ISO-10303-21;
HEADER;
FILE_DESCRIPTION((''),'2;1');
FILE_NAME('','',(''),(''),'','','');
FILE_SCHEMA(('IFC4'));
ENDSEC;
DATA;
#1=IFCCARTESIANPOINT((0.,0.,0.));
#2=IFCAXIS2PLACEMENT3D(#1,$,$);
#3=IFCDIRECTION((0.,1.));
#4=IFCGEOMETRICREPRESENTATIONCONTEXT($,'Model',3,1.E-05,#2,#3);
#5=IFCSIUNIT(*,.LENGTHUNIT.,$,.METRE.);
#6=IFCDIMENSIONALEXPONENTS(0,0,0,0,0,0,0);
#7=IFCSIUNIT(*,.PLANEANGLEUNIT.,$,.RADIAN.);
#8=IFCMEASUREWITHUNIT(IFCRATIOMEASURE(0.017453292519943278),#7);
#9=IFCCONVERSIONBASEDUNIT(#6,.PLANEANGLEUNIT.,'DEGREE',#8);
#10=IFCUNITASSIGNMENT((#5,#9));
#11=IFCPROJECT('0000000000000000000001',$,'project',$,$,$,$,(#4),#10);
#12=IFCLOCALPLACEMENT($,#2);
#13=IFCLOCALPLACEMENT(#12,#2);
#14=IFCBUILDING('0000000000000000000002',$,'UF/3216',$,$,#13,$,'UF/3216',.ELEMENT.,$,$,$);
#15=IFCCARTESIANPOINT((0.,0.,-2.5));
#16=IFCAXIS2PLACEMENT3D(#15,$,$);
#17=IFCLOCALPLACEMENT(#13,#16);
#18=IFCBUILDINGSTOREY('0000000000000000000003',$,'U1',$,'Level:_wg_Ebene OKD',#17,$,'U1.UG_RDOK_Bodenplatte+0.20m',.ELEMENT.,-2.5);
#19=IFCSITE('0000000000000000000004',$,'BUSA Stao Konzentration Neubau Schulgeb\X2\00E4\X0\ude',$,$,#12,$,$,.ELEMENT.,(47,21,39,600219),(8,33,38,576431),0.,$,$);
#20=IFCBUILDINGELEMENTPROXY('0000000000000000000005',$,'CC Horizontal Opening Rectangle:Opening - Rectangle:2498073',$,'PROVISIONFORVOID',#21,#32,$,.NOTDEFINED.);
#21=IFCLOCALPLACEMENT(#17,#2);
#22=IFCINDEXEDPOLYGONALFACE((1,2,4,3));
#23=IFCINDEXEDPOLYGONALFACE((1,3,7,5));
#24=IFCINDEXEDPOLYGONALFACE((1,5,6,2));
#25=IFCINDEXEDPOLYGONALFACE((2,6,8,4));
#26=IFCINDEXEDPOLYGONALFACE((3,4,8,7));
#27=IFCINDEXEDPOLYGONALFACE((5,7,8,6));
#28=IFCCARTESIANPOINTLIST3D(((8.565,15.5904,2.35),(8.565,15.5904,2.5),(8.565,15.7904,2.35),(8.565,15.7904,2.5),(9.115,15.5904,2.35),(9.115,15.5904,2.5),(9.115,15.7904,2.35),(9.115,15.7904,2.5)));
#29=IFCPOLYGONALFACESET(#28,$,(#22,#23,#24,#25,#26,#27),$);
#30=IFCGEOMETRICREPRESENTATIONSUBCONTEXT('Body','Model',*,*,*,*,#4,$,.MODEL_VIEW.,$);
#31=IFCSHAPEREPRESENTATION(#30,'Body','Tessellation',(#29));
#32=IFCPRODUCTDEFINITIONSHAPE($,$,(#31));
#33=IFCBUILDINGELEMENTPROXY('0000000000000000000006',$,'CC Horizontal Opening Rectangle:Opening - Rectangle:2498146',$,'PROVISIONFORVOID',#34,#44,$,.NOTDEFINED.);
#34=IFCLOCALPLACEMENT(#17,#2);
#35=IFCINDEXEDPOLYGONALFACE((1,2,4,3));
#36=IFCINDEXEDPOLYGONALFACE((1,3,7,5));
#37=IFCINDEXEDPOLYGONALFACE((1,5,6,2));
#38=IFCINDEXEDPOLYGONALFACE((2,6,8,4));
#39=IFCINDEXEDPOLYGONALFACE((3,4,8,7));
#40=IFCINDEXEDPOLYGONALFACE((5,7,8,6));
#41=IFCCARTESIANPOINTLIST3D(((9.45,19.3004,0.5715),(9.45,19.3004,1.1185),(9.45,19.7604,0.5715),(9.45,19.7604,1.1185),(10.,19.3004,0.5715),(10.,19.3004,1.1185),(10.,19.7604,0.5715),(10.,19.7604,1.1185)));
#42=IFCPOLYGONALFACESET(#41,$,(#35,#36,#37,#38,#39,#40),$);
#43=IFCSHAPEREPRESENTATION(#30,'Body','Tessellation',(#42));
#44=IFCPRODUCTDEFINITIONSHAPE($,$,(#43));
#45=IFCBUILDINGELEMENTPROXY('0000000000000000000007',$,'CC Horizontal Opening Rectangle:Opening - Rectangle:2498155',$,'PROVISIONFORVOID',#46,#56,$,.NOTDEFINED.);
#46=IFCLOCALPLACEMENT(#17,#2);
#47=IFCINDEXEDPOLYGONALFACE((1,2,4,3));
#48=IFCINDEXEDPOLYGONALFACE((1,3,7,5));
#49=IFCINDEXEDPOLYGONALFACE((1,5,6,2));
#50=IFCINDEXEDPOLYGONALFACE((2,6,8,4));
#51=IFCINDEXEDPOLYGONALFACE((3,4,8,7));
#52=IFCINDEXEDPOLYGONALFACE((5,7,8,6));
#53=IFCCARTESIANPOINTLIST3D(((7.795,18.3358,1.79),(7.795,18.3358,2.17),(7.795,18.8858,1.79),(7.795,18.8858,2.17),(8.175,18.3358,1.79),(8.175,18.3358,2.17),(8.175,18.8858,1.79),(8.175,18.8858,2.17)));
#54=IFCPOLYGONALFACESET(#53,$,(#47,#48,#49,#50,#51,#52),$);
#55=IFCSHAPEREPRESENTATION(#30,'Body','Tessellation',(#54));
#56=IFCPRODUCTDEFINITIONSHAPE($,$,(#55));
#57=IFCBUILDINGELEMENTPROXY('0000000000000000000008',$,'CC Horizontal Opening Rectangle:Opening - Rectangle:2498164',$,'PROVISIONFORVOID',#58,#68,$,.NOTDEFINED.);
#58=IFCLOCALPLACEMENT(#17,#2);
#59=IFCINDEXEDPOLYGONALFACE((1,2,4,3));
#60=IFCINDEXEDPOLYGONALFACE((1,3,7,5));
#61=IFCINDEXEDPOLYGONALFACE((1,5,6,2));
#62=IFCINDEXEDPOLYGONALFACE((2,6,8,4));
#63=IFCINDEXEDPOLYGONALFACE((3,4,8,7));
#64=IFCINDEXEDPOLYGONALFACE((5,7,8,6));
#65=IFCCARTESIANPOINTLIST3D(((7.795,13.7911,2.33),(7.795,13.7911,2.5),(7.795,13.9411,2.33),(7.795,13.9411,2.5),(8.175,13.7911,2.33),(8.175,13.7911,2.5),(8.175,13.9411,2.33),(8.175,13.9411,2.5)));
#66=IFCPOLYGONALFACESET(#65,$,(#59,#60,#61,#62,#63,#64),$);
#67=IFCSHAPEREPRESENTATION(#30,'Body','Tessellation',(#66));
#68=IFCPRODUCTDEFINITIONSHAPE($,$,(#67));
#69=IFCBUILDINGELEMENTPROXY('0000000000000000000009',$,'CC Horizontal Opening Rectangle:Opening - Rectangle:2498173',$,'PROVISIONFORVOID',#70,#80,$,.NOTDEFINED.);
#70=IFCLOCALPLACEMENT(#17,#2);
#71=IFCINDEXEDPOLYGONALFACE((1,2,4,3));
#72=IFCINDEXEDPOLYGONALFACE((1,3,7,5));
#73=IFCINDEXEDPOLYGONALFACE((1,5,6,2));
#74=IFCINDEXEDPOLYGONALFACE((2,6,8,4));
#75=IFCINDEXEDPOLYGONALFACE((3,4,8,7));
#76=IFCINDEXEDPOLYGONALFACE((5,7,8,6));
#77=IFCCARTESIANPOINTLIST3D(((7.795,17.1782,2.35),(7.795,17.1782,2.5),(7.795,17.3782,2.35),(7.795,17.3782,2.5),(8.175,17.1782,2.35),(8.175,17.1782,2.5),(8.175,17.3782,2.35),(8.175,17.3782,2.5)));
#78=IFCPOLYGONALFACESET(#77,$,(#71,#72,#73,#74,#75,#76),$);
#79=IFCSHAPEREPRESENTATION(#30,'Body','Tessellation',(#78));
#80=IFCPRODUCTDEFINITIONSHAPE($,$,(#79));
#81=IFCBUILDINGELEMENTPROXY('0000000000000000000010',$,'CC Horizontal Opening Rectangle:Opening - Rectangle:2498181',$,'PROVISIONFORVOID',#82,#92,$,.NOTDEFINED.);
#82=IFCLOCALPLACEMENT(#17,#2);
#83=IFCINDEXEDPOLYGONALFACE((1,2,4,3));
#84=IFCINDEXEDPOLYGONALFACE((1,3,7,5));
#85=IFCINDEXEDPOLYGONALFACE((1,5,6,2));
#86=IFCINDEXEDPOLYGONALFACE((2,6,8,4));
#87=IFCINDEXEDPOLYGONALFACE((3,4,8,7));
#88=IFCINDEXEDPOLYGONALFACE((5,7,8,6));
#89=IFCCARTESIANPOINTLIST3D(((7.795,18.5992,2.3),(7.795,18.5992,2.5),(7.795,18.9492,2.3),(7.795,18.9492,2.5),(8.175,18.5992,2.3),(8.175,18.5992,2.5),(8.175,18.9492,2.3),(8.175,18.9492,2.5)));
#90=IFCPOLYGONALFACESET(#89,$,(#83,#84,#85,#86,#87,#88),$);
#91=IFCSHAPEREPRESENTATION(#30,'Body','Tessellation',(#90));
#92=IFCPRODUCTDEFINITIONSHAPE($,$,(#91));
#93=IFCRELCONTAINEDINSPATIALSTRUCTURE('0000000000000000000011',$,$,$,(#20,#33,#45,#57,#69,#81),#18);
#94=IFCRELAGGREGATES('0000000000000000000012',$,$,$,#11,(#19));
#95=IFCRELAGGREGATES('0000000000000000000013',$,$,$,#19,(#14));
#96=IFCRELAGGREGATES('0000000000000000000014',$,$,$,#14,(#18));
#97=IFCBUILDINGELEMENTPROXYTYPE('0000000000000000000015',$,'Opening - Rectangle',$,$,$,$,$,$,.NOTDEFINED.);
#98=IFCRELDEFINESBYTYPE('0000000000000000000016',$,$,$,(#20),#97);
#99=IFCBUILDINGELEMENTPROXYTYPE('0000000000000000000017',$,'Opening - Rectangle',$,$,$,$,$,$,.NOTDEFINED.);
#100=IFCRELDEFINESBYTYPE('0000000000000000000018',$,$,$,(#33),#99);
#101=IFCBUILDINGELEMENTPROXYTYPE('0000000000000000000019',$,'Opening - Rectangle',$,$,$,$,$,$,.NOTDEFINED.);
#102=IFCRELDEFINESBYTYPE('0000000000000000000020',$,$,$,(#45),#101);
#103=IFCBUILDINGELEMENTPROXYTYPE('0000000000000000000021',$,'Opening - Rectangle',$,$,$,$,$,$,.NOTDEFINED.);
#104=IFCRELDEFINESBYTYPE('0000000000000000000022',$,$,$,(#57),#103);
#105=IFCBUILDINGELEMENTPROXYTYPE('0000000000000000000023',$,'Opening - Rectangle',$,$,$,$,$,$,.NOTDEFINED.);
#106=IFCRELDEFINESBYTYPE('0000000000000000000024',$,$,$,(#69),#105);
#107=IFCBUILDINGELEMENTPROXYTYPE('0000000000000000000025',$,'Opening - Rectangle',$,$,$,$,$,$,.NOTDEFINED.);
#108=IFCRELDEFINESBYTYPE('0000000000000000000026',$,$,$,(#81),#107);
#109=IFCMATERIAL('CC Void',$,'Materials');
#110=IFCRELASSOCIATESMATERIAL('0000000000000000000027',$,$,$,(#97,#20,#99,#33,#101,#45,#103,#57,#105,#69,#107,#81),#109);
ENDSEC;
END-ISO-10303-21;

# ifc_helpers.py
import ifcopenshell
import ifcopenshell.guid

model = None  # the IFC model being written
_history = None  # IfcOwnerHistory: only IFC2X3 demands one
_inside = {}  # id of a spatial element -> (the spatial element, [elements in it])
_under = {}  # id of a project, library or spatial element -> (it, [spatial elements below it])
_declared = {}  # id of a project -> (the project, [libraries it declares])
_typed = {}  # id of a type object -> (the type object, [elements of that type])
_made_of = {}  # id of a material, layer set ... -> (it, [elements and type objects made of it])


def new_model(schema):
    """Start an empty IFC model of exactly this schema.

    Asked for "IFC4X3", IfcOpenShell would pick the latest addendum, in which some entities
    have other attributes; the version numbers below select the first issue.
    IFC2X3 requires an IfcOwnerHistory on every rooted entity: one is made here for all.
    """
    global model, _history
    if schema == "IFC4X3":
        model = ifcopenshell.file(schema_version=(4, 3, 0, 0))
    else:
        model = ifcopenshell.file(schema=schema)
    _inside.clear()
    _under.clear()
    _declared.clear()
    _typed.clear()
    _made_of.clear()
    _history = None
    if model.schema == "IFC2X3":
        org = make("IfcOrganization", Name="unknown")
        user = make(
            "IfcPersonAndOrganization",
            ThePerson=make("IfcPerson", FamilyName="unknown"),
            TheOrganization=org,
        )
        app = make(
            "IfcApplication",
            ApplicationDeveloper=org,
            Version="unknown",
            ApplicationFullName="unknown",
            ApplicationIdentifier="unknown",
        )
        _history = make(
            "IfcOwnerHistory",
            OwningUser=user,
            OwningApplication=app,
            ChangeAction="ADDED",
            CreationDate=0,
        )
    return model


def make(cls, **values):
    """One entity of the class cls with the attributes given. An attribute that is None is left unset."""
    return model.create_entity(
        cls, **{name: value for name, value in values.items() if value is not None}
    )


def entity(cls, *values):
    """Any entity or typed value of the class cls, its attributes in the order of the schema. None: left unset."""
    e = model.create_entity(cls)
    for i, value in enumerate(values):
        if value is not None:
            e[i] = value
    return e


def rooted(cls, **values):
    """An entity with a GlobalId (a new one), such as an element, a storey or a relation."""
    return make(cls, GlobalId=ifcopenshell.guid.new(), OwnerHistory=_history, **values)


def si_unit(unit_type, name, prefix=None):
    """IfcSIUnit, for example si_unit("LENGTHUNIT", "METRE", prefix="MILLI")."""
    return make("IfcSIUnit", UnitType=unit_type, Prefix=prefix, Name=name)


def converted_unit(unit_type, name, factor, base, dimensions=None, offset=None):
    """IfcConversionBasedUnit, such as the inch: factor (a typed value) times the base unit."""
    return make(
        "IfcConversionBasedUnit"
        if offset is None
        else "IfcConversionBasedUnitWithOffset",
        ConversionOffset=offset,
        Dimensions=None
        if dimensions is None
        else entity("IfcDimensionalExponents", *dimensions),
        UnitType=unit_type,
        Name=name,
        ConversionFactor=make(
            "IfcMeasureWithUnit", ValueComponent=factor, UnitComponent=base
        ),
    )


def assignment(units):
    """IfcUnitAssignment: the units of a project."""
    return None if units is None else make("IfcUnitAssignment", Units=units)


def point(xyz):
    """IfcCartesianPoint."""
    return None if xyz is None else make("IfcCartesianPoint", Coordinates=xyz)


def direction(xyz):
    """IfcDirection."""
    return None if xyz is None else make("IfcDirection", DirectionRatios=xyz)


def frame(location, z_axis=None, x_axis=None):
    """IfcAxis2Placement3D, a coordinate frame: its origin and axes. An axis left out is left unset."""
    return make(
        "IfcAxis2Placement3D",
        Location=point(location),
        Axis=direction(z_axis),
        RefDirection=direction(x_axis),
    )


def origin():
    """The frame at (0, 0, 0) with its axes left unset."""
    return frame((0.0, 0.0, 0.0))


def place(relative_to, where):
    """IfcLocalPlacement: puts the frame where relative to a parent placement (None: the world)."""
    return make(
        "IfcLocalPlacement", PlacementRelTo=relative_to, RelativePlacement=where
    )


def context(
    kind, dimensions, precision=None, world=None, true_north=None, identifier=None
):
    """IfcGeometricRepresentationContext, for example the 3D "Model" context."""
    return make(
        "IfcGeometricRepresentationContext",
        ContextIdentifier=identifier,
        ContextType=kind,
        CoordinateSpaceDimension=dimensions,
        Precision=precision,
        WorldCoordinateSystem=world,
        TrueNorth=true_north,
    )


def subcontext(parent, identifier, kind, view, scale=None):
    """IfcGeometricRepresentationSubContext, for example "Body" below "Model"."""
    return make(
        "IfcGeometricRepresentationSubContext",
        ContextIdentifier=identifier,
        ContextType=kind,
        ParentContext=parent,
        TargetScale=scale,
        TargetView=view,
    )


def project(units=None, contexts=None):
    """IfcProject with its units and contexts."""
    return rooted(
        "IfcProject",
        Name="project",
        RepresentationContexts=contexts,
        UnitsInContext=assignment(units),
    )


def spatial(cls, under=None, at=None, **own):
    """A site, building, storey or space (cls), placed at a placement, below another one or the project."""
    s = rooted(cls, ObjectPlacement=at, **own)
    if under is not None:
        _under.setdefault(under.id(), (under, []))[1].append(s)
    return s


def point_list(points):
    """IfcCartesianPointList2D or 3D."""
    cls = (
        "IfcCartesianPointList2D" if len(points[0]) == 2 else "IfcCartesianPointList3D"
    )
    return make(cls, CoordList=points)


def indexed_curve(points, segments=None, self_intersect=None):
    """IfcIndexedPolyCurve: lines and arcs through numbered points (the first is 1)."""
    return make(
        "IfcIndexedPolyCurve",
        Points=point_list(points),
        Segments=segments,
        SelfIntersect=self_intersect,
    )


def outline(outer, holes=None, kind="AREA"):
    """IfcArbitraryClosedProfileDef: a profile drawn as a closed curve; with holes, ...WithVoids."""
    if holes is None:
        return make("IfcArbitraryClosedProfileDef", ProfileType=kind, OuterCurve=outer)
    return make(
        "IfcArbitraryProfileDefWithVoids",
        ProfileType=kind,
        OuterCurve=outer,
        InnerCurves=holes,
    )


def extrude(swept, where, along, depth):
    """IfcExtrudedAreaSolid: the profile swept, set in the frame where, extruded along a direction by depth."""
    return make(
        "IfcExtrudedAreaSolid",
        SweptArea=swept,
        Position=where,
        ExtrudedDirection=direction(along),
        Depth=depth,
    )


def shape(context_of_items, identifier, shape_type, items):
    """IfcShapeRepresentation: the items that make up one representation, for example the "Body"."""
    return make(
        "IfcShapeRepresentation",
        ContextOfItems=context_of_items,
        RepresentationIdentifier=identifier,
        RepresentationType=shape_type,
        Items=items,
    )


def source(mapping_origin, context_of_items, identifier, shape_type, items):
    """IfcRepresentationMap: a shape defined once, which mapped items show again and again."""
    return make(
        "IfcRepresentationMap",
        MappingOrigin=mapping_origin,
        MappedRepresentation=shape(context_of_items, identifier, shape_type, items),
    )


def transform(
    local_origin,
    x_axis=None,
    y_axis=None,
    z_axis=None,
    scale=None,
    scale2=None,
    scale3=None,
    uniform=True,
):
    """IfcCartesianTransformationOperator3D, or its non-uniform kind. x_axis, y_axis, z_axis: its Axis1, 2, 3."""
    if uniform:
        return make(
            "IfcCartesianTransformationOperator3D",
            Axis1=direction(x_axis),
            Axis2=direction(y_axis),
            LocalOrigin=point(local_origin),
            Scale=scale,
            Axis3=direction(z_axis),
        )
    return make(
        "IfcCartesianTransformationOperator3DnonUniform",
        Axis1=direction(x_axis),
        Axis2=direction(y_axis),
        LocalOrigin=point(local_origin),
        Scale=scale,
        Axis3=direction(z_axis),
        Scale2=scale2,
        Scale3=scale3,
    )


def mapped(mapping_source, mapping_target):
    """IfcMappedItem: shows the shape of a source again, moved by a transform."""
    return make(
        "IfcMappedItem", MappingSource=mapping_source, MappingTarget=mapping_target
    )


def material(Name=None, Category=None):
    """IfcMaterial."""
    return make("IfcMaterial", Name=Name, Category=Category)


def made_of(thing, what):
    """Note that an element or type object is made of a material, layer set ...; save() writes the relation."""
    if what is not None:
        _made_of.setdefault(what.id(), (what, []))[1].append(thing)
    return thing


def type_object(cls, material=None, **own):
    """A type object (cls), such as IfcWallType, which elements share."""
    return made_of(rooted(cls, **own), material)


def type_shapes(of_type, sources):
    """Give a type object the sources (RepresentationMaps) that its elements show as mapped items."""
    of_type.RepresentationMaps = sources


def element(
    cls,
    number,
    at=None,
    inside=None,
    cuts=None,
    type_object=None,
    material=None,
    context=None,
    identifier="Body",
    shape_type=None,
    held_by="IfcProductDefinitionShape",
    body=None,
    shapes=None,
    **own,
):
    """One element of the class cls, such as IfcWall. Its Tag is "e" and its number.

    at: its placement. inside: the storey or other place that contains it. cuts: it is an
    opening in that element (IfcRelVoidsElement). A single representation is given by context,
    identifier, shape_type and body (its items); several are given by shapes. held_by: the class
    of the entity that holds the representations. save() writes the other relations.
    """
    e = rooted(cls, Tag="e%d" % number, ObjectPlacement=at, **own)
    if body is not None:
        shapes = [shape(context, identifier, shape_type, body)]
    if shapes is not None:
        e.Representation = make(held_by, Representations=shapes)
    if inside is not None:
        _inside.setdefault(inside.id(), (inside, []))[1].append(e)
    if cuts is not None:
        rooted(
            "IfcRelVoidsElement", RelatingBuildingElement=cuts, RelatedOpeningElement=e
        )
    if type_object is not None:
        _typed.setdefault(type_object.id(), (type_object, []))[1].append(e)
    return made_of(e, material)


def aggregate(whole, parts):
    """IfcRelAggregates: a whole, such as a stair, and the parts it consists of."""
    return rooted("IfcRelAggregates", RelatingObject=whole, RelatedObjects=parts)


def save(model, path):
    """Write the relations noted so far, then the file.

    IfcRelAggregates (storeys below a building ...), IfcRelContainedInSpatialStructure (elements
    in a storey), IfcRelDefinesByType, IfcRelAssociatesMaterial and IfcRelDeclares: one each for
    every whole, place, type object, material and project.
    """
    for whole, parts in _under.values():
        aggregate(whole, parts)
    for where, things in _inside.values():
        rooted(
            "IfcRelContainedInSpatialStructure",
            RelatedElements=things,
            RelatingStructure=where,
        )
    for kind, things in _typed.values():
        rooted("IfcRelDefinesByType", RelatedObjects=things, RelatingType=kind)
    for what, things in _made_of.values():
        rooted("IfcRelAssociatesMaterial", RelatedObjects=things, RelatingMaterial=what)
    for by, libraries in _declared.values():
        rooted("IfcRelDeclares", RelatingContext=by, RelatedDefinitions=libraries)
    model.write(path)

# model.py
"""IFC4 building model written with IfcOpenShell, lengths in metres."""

from ifc_helpers import new_model, entity, si_unit, converted_unit, direction, frame, origin, place, context, subcontext, project, spatial, indexed_curve, outline, extrude, source, transform, mapped, material, type_object, type_shapes, element, save


model = new_model("IFC4")

# Units and contexts
model_context = context("Model", 3, precision=1e-05, world=origin(), true_north=direction((0.0, 1.0)))
body_context = subcontext(model_context, "Body", "Model", "MODEL_VIEW")
ifc_project = project(units=[si_unit("LENGTHUNIT", "METRE"), converted_unit("PLANEANGLEUNIT", "DEGREE", entity("IfcRatioMeasure", 0.017453292519943278), si_unit("PLANEANGLEUNIT", "RADIAN"), dimensions=[0, 0, 0, 0, 0, 0, 0])], contexts=[model_context])

# Site, building, storey
site_placement = place(None, origin())
site = spatial("IfcSite", under=ifc_project, at=site_placement, Name="BUSA Stao Konzentration Neubau Schulgebäude", CompositionType="ELEMENT", RefLatitude=(47, 21, 39, 600219), RefLongitude=(8, 33, 38, 576431), RefElevation=0.0)
building_placement = place(site_placement, origin())
building = spatial("IfcBuilding", under=site, at=building_placement, Name="UF/3216", LongName="UF/3216", CompositionType="ELEMENT")
storey_placement = place(building_placement, frame((0.0, 0.0, -2.5)))
storey = spatial("IfcBuildingStorey", under=building, at=storey_placement, Name="U1", ObjectType="Level:_wg_Ebene OKD", LongName="U1.UG_RDOK_Bodenplatte+0.20m", CompositionType="ELEMENT", Elevation=-2.5)

# Building element proxies
ifc_material_1 = material(Name="CC Void", Category="Materials")
building_element_proxy_type_1 = type_object("IfcBuildingElementProxyType", Name="Opening - Rectangle", PredefinedType="NOTDEFINED", material=ifc_material_1)
shared_shape_1 = source(origin(), body_context, "Body", "SweptSolid", [
    extrude(outline(indexed_curve([(-0.1, -0.275), (0.1, -0.275), (0.1, 0.275), (-0.1, 0.275), (-0.1, -0.275)], self_intersect=False)), frame((0.0, 0.0, -0.15), z_axis=(0.0, 0.0, 1.0), x_axis=(0.0, -1.0, 0.0)), (0.0, 0.0, 1.0), 0.15),
])
type_shapes(building_element_proxy_type_1, [shared_shape_1])
proxy_1_placement = place(storey_placement, frame((8.84, 15.6904, 2.5)))
element("IfcBuildingElementProxy", 1, at=proxy_1_placement, inside=storey, type_object=building_element_proxy_type_1, material=ifc_material_1, Name="CC Horizontal Opening Rectangle:Opening - Rectangle:2498073", ObjectType="PROVISIONFORVOID", PredefinedType="NOTDEFINED", context=body_context, shape_type="MappedRepresentation", body=[
    mapped(shared_shape_1, transform((0.0, 0.0, 0.0), scale=1.0)),
])
building_element_proxy_type_2 = type_object("IfcBuildingElementProxyType", Name="Opening - Rectangle", PredefinedType="NOTDEFINED", material=ifc_material_1)
shared_shape_2 = source(origin(), body_context, "Body", "SweptSolid", [
    extrude(outline(indexed_curve([(-0.23, -0.275), (0.23, -0.275), (0.23, 0.275), (-0.23, 0.275), (-0.23, -0.275)], self_intersect=False)), frame((0.0, 0.0, -1.9285), z_axis=(0.0, 0.0, 1.0), x_axis=(0.0, -1.0, 0.0)), (0.0, 0.0, 1.0), 0.547),
])
type_shapes(building_element_proxy_type_2, [shared_shape_2])
proxy_2_placement = place(storey_placement, frame((9.725, 19.5304, 2.5)))
element("IfcBuildingElementProxy", 2, at=proxy_2_placement, inside=storey, type_object=building_element_proxy_type_2, material=ifc_material_1, Name="CC Horizontal Opening Rectangle:Opening - Rectangle:2498146", ObjectType="PROVISIONFORVOID", PredefinedType="NOTDEFINED", context=body_context, shape_type="MappedRepresentation", body=[
    mapped(shared_shape_2, transform((0.0, 0.0, 0.0), scale=1.0)),
])
building_element_proxy_type_3 = type_object("IfcBuildingElementProxyType", Name="Opening - Rectangle", PredefinedType="NOTDEFINED", material=ifc_material_1)
shared_shape_3 = source(origin(), body_context, "Body", "SweptSolid", [
    extrude(outline(indexed_curve([(-0.19, -0.275), (0.19, -0.275), (0.19, 0.275), (-0.19, 0.275), (-0.19, -0.275)], self_intersect=False)), frame((0.0, 0.0, -0.71), z_axis=(0.0, 0.0, 1.0), x_axis=(0.0, -1.0, 0.0)), (0.0, 0.0, 1.0), 0.38),
])
type_shapes(building_element_proxy_type_3, [shared_shape_3])
proxy_3_placement = place(storey_placement, frame((7.985, 18.6108, 2.5), z_axis=(0.0, 0.0, 1.0), x_axis=(0.0, -1.0, 0.0)))
element("IfcBuildingElementProxy", 3, at=proxy_3_placement, inside=storey, type_object=building_element_proxy_type_3, material=ifc_material_1, Name="CC Horizontal Opening Rectangle:Opening - Rectangle:2498155", ObjectType="PROVISIONFORVOID", PredefinedType="NOTDEFINED", context=body_context, shape_type="MappedRepresentation", body=[
    mapped(shared_shape_3, transform((0.0, 0.0, 0.0), scale=1.0)),
])
building_element_proxy_type_4 = type_object("IfcBuildingElementProxyType", Name="Opening - Rectangle", PredefinedType="NOTDEFINED", material=ifc_material_1)
shared_shape_4 = source(origin(), body_context, "Body", "SweptSolid", [
    extrude(outline(indexed_curve([(-0.19, -0.075), (0.19, -0.075), (0.19, 0.075), (-0.19, 0.075), (-0.19, -0.075)], self_intersect=False)), frame((0.0, 0.0, -0.17), z_axis=(0.0, 0.0, 1.0), x_axis=(0.0, -1.0, 0.0)), (0.0, 0.0, 1.0), 0.17),
])
type_shapes(building_element_proxy_type_4, [shared_shape_4])
proxy_4_placement = place(storey_placement, frame((7.985, 13.8661, 2.5), z_axis=(0.0, 0.0, 1.0), x_axis=(0.0, -1.0, 0.0)))
element("IfcBuildingElementProxy", 4, at=proxy_4_placement, inside=storey, type_object=building_element_proxy_type_4, material=ifc_material_1, Name="CC Horizontal Opening Rectangle:Opening - Rectangle:2498164", ObjectType="PROVISIONFORVOID", PredefinedType="NOTDEFINED", context=body_context, shape_type="MappedRepresentation", body=[
    mapped(shared_shape_4, transform((0.0, 0.0, 0.0), scale=1.0)),
])
building_element_proxy_type_5 = type_object("IfcBuildingElementProxyType", Name="Opening - Rectangle", PredefinedType="NOTDEFINED", material=ifc_material_1)
shared_shape_5 = source(origin(), body_context, "Body", "SweptSolid", [
    extrude(outline(indexed_curve([(-0.19, -0.1), (0.19, -0.1), (0.19, 0.1), (-0.19, 0.1), (-0.19, -0.1)], self_intersect=False)), frame((0.0, 0.0, -0.15), z_axis=(0.0, 0.0, 1.0), x_axis=(0.0, -1.0, 0.0)), (0.0, 0.0, 1.0), 0.15),
])
type_shapes(building_element_proxy_type_5, [shared_shape_5])
proxy_5_placement = place(storey_placement, frame((7.985, 17.2782, 2.5), z_axis=(0.0, 0.0, 1.0), x_axis=(0.0, -1.0, 0.0)))
element("IfcBuildingElementProxy", 5, at=proxy_5_placement, inside=storey, type_object=building_element_proxy_type_5, material=ifc_material_1, Name="CC Horizontal Opening Rectangle:Opening - Rectangle:2498173", ObjectType="PROVISIONFORVOID", PredefinedType="NOTDEFINED", context=body_context, shape_type="MappedRepresentation", body=[
    mapped(shared_shape_5, transform((0.0, 0.0, 0.0), scale=1.0)),
])
building_element_proxy_type_6 = type_object("IfcBuildingElementProxyType", Name="Opening - Rectangle", PredefinedType="NOTDEFINED", material=ifc_material_1)
shared_shape_6 = source(origin(), body_context, "Body", "SweptSolid", [
    extrude(outline(indexed_curve([(-0.19, -0.175), (0.19, -0.175), (0.19, 0.175), (-0.19, 0.175), (-0.19, -0.175)], self_intersect=False)), frame((0.0, 0.0, -0.2), z_axis=(0.0, 0.0, 1.0), x_axis=(0.0, -1.0, 0.0)), (0.0, 0.0, 1.0), 0.2),
])
type_shapes(building_element_proxy_type_6, [shared_shape_6])
proxy_6_placement = place(storey_placement, frame((7.985, 18.7742, 2.5), z_axis=(0.0, 0.0, 1.0), x_axis=(0.0, -1.0, 0.0)))
element("IfcBuildingElementProxy", 6, at=proxy_6_placement, inside=storey, type_object=building_element_proxy_type_6, material=ifc_material_1, Name="CC Horizontal Opening Rectangle:Opening - Rectangle:2498181", ObjectType="PROVISIONFORVOID", PredefinedType="NOTDEFINED", context=body_context, shape_type="MappedRepresentation", body=[
    mapped(shared_shape_6, transform((0.0, 0.0, 0.0), scale=1.0)),
])

save(model, "model.ifc")
